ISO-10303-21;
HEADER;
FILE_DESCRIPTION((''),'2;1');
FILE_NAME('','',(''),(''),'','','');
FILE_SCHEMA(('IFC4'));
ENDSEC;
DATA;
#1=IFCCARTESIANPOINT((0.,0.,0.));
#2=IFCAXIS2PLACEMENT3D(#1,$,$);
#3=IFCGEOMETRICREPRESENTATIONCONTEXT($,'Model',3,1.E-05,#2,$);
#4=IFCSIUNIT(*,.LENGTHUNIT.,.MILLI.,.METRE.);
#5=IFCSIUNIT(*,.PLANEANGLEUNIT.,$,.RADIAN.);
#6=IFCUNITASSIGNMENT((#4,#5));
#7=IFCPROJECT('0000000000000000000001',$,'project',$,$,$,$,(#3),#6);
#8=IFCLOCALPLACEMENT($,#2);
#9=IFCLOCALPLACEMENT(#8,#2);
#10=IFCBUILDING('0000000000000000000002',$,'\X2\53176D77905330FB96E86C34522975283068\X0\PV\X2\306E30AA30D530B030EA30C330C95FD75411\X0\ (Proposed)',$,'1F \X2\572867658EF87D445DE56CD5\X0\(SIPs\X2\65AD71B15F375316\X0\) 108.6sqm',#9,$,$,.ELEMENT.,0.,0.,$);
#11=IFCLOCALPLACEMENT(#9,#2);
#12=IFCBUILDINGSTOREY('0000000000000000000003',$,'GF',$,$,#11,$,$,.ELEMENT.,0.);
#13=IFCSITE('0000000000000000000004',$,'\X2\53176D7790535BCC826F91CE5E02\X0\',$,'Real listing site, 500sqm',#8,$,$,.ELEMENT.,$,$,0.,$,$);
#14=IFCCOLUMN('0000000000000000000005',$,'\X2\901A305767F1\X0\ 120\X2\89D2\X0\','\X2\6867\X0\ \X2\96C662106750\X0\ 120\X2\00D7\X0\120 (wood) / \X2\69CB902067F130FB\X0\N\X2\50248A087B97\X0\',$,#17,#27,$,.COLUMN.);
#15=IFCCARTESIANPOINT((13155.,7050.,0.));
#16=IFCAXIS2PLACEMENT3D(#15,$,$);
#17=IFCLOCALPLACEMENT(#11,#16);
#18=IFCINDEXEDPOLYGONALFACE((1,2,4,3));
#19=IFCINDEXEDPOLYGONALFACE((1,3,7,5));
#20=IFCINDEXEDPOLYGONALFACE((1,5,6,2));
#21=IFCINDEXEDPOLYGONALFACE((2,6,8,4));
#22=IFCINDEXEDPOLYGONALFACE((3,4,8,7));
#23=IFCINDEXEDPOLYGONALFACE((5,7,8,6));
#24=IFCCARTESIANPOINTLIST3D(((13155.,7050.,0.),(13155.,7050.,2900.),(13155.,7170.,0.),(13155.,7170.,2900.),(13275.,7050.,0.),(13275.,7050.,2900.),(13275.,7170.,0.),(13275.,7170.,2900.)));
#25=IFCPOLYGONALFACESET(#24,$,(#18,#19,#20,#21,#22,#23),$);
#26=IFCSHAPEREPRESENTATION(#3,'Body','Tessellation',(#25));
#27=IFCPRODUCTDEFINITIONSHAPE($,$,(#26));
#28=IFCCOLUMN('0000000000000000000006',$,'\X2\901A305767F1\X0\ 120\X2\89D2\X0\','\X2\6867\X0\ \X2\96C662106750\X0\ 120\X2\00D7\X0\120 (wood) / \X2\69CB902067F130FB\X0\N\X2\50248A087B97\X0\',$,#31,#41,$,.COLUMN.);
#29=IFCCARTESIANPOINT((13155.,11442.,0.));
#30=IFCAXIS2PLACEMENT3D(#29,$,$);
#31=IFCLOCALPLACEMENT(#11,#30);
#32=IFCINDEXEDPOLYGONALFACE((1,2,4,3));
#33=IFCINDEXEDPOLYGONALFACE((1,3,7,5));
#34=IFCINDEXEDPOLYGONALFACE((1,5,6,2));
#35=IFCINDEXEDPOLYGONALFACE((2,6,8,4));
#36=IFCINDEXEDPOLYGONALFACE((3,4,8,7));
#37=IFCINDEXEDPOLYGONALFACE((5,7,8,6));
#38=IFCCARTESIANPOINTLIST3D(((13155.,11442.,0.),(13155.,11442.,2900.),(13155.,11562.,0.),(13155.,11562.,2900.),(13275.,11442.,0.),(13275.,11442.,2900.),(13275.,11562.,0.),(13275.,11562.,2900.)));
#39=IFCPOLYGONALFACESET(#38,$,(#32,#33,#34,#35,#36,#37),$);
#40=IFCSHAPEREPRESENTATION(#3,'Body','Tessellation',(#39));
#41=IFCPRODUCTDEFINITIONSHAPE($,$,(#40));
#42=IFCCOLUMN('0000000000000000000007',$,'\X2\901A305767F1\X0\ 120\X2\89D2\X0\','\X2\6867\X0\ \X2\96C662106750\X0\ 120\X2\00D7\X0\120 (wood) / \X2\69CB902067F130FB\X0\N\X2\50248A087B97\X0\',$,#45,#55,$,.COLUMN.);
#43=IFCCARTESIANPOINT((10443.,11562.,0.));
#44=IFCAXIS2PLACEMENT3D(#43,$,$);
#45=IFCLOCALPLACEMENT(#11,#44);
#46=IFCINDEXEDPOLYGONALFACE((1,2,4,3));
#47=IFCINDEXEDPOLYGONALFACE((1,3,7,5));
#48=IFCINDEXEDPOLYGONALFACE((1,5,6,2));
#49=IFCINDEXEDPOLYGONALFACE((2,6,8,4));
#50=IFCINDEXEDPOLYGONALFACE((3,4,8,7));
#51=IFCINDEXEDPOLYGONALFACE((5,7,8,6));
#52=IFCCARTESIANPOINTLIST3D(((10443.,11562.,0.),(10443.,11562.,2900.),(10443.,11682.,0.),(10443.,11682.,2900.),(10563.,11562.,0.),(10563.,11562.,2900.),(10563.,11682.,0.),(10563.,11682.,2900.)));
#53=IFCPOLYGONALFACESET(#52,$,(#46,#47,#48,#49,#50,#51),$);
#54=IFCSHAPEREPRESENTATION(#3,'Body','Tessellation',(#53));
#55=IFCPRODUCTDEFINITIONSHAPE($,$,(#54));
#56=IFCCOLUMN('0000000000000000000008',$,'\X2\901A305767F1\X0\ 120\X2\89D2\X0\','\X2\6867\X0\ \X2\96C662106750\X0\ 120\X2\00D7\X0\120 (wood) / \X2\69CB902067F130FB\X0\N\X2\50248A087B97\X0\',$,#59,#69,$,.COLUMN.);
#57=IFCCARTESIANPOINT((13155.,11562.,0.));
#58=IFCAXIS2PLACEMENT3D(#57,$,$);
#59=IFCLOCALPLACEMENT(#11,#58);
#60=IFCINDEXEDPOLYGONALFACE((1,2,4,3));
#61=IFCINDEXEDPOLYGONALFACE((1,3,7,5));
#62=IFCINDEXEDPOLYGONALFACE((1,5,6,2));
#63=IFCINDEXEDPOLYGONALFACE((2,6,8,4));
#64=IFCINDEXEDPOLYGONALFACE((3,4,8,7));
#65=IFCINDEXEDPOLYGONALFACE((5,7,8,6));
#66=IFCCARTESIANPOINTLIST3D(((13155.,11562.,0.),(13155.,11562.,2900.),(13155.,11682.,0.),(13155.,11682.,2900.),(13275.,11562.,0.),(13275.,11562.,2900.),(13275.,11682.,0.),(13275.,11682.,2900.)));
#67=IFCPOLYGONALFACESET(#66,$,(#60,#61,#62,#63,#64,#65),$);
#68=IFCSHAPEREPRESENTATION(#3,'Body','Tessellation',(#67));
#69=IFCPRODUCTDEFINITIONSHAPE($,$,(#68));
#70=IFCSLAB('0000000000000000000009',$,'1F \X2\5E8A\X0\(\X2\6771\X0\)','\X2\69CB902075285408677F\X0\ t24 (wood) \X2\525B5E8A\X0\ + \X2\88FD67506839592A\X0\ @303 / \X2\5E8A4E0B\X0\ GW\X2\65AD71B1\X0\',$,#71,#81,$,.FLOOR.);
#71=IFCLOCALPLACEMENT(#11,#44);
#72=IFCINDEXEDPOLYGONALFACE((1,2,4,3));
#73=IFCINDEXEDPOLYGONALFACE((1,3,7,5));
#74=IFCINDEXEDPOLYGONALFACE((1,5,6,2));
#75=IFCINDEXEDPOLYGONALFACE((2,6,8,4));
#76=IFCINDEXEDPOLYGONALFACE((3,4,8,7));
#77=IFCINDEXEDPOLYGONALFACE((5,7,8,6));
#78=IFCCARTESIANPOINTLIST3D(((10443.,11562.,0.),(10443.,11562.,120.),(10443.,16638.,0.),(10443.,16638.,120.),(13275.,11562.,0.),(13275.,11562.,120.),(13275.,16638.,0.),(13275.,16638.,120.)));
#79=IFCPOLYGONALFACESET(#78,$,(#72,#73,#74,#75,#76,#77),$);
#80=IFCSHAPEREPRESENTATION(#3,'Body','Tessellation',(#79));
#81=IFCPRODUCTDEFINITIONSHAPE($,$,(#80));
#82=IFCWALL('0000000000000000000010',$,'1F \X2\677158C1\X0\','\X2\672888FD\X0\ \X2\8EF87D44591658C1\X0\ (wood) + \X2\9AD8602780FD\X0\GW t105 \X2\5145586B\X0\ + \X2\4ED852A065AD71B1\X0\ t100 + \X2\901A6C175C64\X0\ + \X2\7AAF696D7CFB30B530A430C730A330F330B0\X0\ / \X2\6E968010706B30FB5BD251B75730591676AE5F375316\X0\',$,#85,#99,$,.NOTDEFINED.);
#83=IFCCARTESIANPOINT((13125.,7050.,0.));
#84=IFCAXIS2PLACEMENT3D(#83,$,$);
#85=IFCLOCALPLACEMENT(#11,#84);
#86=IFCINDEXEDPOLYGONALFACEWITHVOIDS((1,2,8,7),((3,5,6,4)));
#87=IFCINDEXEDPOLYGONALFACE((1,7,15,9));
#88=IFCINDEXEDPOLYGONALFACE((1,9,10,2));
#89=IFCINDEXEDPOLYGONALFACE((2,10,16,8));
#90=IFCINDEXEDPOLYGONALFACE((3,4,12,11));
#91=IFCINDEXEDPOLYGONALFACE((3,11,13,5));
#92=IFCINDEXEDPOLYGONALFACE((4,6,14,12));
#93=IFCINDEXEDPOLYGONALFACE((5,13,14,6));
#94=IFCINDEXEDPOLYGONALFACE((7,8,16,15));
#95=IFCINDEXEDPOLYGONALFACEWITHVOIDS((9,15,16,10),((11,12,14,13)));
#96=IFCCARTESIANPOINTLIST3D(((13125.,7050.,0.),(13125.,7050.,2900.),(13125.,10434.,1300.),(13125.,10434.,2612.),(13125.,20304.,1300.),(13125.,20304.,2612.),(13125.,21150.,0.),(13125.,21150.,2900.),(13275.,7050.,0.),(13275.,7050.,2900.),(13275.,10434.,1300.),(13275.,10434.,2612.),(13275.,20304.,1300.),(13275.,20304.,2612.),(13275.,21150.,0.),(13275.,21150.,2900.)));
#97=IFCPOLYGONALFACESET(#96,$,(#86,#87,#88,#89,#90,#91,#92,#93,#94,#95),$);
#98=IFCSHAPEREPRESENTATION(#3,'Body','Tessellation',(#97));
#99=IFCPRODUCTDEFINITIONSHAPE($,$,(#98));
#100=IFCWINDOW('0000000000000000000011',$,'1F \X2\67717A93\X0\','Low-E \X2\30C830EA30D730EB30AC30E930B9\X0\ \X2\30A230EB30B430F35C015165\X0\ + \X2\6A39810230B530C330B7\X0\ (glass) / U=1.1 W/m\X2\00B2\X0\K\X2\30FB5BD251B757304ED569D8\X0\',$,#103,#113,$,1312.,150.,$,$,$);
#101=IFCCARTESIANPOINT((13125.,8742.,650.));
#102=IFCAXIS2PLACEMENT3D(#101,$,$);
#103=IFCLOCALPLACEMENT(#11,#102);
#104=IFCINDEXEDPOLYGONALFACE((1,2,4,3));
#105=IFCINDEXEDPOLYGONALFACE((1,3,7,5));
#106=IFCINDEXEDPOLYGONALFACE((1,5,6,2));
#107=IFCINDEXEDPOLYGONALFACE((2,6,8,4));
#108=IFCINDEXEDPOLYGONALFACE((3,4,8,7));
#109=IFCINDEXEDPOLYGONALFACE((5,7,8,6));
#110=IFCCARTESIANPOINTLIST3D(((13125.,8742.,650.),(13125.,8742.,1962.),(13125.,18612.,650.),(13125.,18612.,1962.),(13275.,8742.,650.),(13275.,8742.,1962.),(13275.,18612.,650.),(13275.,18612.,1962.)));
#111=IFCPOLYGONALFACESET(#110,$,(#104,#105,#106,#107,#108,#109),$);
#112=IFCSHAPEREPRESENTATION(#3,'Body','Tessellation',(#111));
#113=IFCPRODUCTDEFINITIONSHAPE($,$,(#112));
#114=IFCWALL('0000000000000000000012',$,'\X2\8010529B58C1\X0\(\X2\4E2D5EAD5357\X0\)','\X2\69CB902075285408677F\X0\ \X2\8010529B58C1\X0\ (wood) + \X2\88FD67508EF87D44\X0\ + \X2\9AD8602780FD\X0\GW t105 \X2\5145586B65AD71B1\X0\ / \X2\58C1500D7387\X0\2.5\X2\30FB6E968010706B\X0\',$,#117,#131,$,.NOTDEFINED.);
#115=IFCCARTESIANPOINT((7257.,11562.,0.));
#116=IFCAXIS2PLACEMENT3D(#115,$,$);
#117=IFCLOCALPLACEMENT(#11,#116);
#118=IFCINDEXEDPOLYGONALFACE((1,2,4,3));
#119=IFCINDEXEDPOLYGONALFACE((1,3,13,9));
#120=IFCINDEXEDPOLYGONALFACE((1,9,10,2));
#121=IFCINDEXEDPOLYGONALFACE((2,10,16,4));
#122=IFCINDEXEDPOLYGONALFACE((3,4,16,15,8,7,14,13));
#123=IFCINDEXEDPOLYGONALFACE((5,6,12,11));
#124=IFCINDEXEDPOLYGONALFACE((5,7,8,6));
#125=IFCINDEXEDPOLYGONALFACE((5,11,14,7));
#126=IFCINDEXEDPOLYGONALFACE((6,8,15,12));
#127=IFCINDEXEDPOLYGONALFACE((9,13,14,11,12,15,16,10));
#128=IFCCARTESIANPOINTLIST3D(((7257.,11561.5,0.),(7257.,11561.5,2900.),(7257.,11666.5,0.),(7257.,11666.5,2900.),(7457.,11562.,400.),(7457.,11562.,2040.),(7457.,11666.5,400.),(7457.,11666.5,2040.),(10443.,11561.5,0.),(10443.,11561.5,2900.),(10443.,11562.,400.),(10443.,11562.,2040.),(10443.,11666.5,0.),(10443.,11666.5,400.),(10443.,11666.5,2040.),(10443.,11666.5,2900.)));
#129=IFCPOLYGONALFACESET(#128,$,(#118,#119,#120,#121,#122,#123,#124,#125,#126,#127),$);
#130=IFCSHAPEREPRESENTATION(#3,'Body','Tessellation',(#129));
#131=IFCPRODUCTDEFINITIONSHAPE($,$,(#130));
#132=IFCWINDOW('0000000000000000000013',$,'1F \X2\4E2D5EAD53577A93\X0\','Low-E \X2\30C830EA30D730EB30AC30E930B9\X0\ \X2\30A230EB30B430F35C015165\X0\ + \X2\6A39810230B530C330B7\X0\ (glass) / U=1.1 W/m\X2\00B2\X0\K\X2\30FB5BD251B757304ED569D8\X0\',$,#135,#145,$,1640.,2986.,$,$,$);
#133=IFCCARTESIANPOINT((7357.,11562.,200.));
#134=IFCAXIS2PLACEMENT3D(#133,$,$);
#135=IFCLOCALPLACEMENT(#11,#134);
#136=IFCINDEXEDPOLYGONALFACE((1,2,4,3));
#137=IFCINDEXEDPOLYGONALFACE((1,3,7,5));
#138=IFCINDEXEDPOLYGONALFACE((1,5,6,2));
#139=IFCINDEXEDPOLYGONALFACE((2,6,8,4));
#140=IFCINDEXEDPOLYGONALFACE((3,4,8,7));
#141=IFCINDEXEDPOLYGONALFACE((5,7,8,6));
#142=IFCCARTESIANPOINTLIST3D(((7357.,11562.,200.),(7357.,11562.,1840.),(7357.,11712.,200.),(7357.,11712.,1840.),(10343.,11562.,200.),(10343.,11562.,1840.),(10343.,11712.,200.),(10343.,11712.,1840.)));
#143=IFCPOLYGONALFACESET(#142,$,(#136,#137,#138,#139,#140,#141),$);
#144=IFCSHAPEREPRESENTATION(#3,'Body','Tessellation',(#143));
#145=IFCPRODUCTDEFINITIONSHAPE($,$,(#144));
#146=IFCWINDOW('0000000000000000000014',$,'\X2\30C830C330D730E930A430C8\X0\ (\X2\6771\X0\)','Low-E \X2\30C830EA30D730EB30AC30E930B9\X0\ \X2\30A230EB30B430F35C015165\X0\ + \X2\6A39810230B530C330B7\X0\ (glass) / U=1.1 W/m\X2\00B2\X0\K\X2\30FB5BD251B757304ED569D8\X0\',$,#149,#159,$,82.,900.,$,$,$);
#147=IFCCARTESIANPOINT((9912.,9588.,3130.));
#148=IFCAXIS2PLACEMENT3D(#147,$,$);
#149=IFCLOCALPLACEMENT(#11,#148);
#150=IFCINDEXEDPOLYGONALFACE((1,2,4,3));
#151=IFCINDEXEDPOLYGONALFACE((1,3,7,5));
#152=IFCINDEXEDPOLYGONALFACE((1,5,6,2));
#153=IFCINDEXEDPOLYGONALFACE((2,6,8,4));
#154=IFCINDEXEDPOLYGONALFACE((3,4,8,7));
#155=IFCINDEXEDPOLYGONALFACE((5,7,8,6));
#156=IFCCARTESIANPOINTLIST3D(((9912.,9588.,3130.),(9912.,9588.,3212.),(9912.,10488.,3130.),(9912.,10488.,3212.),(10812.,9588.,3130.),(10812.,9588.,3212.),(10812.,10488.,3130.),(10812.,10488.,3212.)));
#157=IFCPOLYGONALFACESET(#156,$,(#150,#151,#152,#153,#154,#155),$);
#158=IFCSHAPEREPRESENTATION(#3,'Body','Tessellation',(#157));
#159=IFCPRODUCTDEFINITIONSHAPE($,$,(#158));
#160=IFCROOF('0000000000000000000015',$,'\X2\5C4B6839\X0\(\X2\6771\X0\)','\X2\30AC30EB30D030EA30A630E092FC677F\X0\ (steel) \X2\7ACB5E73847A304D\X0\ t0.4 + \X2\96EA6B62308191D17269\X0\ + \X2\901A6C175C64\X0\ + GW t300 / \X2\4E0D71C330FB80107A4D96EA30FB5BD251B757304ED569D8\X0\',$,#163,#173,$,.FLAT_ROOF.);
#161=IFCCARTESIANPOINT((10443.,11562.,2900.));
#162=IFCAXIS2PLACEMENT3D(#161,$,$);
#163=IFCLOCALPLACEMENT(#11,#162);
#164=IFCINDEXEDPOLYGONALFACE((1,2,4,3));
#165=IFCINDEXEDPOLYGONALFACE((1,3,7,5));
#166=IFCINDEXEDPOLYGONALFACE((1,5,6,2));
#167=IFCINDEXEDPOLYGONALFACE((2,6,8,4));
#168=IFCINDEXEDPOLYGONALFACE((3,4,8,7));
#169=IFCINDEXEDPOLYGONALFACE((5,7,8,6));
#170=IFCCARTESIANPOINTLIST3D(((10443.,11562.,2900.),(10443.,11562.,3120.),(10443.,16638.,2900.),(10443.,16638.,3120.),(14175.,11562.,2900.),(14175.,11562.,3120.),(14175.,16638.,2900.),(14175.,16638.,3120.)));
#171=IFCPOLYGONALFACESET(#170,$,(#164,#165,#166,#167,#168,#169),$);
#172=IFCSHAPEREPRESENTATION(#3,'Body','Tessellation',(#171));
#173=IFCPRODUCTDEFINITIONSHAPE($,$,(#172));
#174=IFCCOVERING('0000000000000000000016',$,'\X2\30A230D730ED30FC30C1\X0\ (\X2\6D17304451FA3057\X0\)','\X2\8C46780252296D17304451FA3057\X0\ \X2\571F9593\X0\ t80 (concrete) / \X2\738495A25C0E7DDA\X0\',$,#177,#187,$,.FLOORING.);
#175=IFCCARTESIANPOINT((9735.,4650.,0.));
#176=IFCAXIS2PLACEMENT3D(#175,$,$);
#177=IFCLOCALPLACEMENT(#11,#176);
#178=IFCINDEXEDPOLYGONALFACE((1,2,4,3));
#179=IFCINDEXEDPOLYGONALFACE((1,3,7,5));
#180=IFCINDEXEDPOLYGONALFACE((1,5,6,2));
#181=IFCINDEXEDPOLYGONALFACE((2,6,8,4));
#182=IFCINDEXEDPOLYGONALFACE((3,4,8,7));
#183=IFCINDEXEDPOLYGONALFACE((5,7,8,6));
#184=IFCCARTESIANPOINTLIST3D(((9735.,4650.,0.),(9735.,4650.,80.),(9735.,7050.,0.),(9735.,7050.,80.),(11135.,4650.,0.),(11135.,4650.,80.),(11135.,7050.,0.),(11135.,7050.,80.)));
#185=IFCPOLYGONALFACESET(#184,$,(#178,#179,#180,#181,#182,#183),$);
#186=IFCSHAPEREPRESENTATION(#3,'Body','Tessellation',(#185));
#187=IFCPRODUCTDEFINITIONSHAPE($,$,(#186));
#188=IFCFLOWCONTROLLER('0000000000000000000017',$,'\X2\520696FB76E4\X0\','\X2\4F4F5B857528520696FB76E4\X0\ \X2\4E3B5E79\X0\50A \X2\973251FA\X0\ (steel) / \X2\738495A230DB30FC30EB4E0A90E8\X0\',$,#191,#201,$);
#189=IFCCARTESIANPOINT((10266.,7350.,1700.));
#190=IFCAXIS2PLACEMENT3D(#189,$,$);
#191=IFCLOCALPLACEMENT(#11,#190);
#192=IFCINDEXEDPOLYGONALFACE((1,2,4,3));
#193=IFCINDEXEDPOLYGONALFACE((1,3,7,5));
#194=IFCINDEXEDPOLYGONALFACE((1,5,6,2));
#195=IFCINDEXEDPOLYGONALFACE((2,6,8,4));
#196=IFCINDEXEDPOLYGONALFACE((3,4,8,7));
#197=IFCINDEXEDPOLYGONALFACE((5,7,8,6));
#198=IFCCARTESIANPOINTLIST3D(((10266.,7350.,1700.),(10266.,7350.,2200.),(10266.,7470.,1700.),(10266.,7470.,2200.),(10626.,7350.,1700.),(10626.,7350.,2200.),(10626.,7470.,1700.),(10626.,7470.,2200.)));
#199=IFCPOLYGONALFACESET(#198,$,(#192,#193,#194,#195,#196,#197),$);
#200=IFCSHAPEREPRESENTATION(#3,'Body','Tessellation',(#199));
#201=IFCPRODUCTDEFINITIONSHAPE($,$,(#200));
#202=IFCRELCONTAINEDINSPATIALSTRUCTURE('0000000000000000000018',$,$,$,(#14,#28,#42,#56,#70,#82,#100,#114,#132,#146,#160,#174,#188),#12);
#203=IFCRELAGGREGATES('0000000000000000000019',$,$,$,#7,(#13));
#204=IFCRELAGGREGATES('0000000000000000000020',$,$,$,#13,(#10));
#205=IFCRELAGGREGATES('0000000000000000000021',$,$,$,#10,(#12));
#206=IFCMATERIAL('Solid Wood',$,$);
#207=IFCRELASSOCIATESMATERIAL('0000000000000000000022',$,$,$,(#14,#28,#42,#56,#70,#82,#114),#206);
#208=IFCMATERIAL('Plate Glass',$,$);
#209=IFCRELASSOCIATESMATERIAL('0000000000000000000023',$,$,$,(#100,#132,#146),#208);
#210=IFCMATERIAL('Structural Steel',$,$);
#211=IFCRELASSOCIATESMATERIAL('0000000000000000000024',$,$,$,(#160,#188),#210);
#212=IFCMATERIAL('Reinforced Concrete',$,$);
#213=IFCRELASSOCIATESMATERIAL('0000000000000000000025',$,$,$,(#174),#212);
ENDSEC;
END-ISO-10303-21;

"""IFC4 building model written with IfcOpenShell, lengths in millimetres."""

from ifc_helpers import new_model, si_unit, frame, frame_2d, origin, place, context, project, spatial, rectangle, extrude, material, element, fill, save


model = new_model("IFC4")

# Units and contexts
model_context = context("Model", 3, precision=1e-05, world=origin())
ifc_project = project(units=[si_unit("LENGTHUNIT", "METRE", prefix="MILLI"), si_unit("PLANEANGLEUNIT", "RADIAN")], contexts=[model_context])

# Site, building, storey
site_placement = place(None, origin())
site = spatial("IfcSite", under=ifc_project, at=site_placement, Name="北海道富良野市", ObjectType="Real listing site, 500sqm", CompositionType="ELEMENT", RefElevation=0.0)
building_placement = place(site_placement, origin())
building = spatial("IfcBuilding", under=site, at=building_placement, Name="北海道・雨水利用とPVのオフグリッド志向 (Proposed)", ObjectType="1F 在来軸組工法(SIPs断熱強化) 108.6sqm", CompositionType="ELEMENT", ElevationOfRefHeight=0.0, ElevationOfTerrain=0.0)
storey_placement = place(building_placement, origin())
storey = spatial("IfcBuildingStorey", under=building, at=storey_placement, Name="GF", CompositionType="ELEMENT", Elevation=0.0)

# Columns
ifc_material_1 = material(Name="Solid Wood")
column_1_placement = place(storey_placement, frame((13155.0, 7050.0, 0.0)))
element("IfcColumn", 1, at=column_1_placement, inside=storey, material=ifc_material_1, Name="通し柱 120角", Description="桧 集成材 120×120 (wood) / 構造柱・N値計算", PredefinedType="COLUMN", context=model_context, shape_type="SweptSolid", body=[
    extrude(rectangle(XDim=120.0, YDim=120.0, at=frame_2d((60.0, 60.0))), frame((13155.0, 7050.0, 0.0)), (0.0, 0.0, 1.0), 2900.0),
])
column_2_placement = place(storey_placement, frame((13155.0, 11442.0, 0.0)))
element("IfcColumn", 2, at=column_2_placement, inside=storey, material=ifc_material_1, Name="通し柱 120角", Description="桧 集成材 120×120 (wood) / 構造柱・N値計算", PredefinedType="COLUMN", context=model_context, shape_type="SweptSolid", body=[
    extrude(rectangle(XDim=120.0, YDim=120.0, at=frame_2d((60.0, 60.0))), frame((13155.0, 11442.0, 0.0)), (0.0, 0.0, 1.0), 2900.0),
])
column_3_placement = place(storey_placement, frame((10443.0, 11562.0, 0.0)))
element("IfcColumn", 3, at=column_3_placement, inside=storey, material=ifc_material_1, Name="通し柱 120角", Description="桧 集成材 120×120 (wood) / 構造柱・N値計算", PredefinedType="COLUMN", context=model_context, shape_type="SweptSolid", body=[
    extrude(rectangle(XDim=120.0, YDim=120.0, at=frame_2d((60.0, 60.0))), frame((10443.0, 11562.0, 0.0)), (0.0, 0.0, 1.0), 2900.0),
])
column_4_placement = place(storey_placement, frame((13155.0, 11562.0, 0.0)))
element("IfcColumn", 4, at=column_4_placement, inside=storey, material=ifc_material_1, Name="通し柱 120角", Description="桧 集成材 120×120 (wood) / 構造柱・N値計算", PredefinedType="COLUMN", context=model_context, shape_type="SweptSolid", body=[
    extrude(rectangle(XDim=120.0, YDim=120.0, at=frame_2d((60.0, 60.0))), frame((13155.0, 11562.0, 0.0)), (0.0, 0.0, 1.0), 2900.0),
])

# Slab
slab_placement = place(storey_placement, frame((10443.0, 11562.0, 0.0)))
element("IfcSlab", 5, at=slab_placement, inside=storey, material=ifc_material_1, Name="1F 床(東)", Description="構造用合板 t24 (wood) 剛床 + 製材根太 @303 / 床下 GW断熱", PredefinedType="FLOOR", context=model_context, shape_type="SweptSolid", body=[
    extrude(rectangle(XDim=2832.0, YDim=5076.0, at=frame_2d((1416.0, 2538.0))), frame((10443.0, 11562.0, 0.0)), (0.0, 0.0, 1.0), 120.0),
])

# Walls, openings, windows
wall_1_placement = place(storey_placement, frame((13125.0, 7050.0, 0.0)))
wall_1 = element("IfcWall", 6, at=wall_1_placement, inside=storey, material=ifc_material_1, Name="1F 東壁", Description="木製 軸組外壁 (wood) + 高性能GW t105 充填 + 付加断熱 t100 + 通気層 + 窯業系サイディング / 準耐火・寒冷地外皮強化", PredefinedType="NOTDEFINED", context=model_context, shape_type="SweptSolid", body=[
    extrude(rectangle(XDim=150.0, YDim=14100.0, at=frame_2d((75.0, 7050.0))), frame((13125.0, 7050.0, 0.0)), (0.0, 0.0, 1.0), 2900.0),
])
opening_1_placement = place(storey_placement, frame((13125.0, 8742.0, 650.0)))
opening_1 = element("IfcOpeningElement", 7, at=opening_1_placement, cuts=wall_1, PredefinedType="NOTDEFINED", context=model_context, shape_type="SweptSolid", body=[
    extrude(rectangle(XDim=150.0, YDim=9870.0, at=frame_2d((75.0, 4935.0))), frame((13125.0, 8742.0, 650.0)), (0.0, 0.0, 1.0), 1312.0),
])
ifc_material_2 = material(Name="Plate Glass")
window_1_placement = place(storey_placement, frame((13125.0, 8742.0, 650.0)))
window_1 = element("IfcWindow", 8, at=window_1_placement, inside=storey, material=ifc_material_2, Name="1F 東窓", Description="Low-E トリプルガラス アルゴン封入 + 樹脂サッシ (glass) / U=1.1 W/m²K・寒冷地仕様", OverallHeight=1312.0, OverallWidth=150.0, context=model_context, shape_type="SweptSolid", body=[
    extrude(rectangle(XDim=150.0, YDim=9870.0, at=frame_2d((75.0, 4935.0))), frame((13125.0, 8742.0, 650.0)), (0.0, 0.0, 1.0), 1312.0),
])
fill(opening_1, window_1)
wall_2_placement = place(storey_placement, frame((7257.0, 11562.0, 0.0)))
wall_2 = element("IfcWall", 9, at=wall_2_placement, inside=storey, material=ifc_material_1, Name="耐力壁(中庭南)", Description="構造用合板 耐力壁 (wood) + 製材軸組 + 高性能GW t105 充填断熱 / 壁倍率2.5・準耐火", PredefinedType="NOTDEFINED", context=model_context, shape_type="SweptSolid", body=[
    extrude(rectangle(XDim=3186.0, YDim=105.0, at=frame_2d((1593.0, 52.0))), frame((7257.0, 11562.0, 0.0)), (0.0, 0.0, 1.0), 2900.0),
])
opening_2_placement = place(storey_placement, frame((7357.0, 11562.0, 200.0)))
opening_2 = element("IfcOpeningElement", 10, at=opening_2_placement, cuts=wall_2, PredefinedType="NOTDEFINED", context=model_context, shape_type="SweptSolid", body=[
    extrude(rectangle(XDim=2986.0, YDim=150.0, at=frame_2d((1493.0, 75.0))), frame((7357.0, 11562.0, 200.0)), (0.0, 0.0, 1.0), 1640.0),
])
window_2_placement = place(storey_placement, frame((7357.0, 11562.0, 200.0)))
window_2 = element("IfcWindow", 11, at=window_2_placement, inside=storey, material=ifc_material_2, Name="1F 中庭南窓", Description="Low-E トリプルガラス アルゴン封入 + 樹脂サッシ (glass) / U=1.1 W/m²K・寒冷地仕様", OverallHeight=1640.0, OverallWidth=2986.0, context=model_context, shape_type="SweptSolid", body=[
    extrude(rectangle(XDim=2986.0, YDim=150.0, at=frame_2d((1493.0, 75.0))), frame((7357.0, 11562.0, 200.0)), (0.0, 0.0, 1.0), 1640.0),
])
fill(opening_2, window_2)

# Window
window_3_placement = place(storey_placement, frame((9912.0, 9588.0, 3130.0)))
element("IfcWindow", 12, at=window_3_placement, inside=storey, material=ifc_material_2, Name="トップライト (東)", Description="Low-E トリプルガラス アルゴン封入 + 樹脂サッシ (glass) / U=1.1 W/m²K・寒冷地仕様", OverallHeight=82.0, OverallWidth=900.0, context=model_context, shape_type="SweptSolid", body=[
    extrude(rectangle(XDim=900.0, YDim=900.0, at=frame_2d((450.0, 450.0))), frame((9912.0, 9588.0, 3130.0)), (0.0, 0.0, 1.0), 82.0),
])

# Roof
ifc_material_3 = material(Name="Structural Steel")
roof_placement = place(storey_placement, frame((10443.0, 11562.0, 2900.0)))
element("IfcRoof", 13, at=roof_placement, inside=storey, material=ifc_material_3, Name="屋根(東)", Description="ガルバリウム鋼板 (steel) 立平葺き t0.4 + 雪止め金物 + 通気層 + GW t300 / 不燃・耐積雪・寒冷地仕様", PredefinedType="FLAT_ROOF", context=model_context, shape_type="SweptSolid", body=[
    extrude(rectangle(XDim=3732.0, YDim=5076.0, at=frame_2d((1866.0, 2538.0))), frame((10443.0, 11562.0, 2900.0)), (0.0, 0.0, 1.0), 220.0),
])

# Covering
ifc_material_4 = material(Name="Reinforced Concrete")
covering_placement = place(storey_placement, frame((9735.0, 4650.0, 0.0)))
element("IfcCovering", 14, at=covering_placement, inside=storey, material=ifc_material_4, Name="アプローチ (洗い出し)", Description="豆砂利洗い出し 土間 t80 (concrete) / 玄関導線", PredefinedType="FLOORING", context=model_context, shape_type="SweptSolid", body=[
    extrude(rectangle(XDim=1400.0, YDim=2400.0, at=frame_2d((700.0, 1200.0))), frame((9735.0, 4650.0, 0.0)), (0.0, 0.0, 1.0), 80.0),
])

# Flow controller
flow_controller_placement = place(storey_placement, frame((10266.0, 7350.0, 1700.0)))
element("IfcFlowController", 15, at=flow_controller_placement, inside=storey, material=ifc_material_3, Name="分電盤", Description="住宅用分電盤 主幹50A 露出 (steel) / 玄関ホール上部", context=model_context, shape_type="SweptSolid", body=[
    extrude(rectangle(XDim=360.0, YDim=120.0, at=frame_2d((180.0, 60.0))), frame((10266.0, 7350.0, 1700.0)), (0.0, 0.0, 1.0), 500.0),
])

save(model, "model.ifc")
